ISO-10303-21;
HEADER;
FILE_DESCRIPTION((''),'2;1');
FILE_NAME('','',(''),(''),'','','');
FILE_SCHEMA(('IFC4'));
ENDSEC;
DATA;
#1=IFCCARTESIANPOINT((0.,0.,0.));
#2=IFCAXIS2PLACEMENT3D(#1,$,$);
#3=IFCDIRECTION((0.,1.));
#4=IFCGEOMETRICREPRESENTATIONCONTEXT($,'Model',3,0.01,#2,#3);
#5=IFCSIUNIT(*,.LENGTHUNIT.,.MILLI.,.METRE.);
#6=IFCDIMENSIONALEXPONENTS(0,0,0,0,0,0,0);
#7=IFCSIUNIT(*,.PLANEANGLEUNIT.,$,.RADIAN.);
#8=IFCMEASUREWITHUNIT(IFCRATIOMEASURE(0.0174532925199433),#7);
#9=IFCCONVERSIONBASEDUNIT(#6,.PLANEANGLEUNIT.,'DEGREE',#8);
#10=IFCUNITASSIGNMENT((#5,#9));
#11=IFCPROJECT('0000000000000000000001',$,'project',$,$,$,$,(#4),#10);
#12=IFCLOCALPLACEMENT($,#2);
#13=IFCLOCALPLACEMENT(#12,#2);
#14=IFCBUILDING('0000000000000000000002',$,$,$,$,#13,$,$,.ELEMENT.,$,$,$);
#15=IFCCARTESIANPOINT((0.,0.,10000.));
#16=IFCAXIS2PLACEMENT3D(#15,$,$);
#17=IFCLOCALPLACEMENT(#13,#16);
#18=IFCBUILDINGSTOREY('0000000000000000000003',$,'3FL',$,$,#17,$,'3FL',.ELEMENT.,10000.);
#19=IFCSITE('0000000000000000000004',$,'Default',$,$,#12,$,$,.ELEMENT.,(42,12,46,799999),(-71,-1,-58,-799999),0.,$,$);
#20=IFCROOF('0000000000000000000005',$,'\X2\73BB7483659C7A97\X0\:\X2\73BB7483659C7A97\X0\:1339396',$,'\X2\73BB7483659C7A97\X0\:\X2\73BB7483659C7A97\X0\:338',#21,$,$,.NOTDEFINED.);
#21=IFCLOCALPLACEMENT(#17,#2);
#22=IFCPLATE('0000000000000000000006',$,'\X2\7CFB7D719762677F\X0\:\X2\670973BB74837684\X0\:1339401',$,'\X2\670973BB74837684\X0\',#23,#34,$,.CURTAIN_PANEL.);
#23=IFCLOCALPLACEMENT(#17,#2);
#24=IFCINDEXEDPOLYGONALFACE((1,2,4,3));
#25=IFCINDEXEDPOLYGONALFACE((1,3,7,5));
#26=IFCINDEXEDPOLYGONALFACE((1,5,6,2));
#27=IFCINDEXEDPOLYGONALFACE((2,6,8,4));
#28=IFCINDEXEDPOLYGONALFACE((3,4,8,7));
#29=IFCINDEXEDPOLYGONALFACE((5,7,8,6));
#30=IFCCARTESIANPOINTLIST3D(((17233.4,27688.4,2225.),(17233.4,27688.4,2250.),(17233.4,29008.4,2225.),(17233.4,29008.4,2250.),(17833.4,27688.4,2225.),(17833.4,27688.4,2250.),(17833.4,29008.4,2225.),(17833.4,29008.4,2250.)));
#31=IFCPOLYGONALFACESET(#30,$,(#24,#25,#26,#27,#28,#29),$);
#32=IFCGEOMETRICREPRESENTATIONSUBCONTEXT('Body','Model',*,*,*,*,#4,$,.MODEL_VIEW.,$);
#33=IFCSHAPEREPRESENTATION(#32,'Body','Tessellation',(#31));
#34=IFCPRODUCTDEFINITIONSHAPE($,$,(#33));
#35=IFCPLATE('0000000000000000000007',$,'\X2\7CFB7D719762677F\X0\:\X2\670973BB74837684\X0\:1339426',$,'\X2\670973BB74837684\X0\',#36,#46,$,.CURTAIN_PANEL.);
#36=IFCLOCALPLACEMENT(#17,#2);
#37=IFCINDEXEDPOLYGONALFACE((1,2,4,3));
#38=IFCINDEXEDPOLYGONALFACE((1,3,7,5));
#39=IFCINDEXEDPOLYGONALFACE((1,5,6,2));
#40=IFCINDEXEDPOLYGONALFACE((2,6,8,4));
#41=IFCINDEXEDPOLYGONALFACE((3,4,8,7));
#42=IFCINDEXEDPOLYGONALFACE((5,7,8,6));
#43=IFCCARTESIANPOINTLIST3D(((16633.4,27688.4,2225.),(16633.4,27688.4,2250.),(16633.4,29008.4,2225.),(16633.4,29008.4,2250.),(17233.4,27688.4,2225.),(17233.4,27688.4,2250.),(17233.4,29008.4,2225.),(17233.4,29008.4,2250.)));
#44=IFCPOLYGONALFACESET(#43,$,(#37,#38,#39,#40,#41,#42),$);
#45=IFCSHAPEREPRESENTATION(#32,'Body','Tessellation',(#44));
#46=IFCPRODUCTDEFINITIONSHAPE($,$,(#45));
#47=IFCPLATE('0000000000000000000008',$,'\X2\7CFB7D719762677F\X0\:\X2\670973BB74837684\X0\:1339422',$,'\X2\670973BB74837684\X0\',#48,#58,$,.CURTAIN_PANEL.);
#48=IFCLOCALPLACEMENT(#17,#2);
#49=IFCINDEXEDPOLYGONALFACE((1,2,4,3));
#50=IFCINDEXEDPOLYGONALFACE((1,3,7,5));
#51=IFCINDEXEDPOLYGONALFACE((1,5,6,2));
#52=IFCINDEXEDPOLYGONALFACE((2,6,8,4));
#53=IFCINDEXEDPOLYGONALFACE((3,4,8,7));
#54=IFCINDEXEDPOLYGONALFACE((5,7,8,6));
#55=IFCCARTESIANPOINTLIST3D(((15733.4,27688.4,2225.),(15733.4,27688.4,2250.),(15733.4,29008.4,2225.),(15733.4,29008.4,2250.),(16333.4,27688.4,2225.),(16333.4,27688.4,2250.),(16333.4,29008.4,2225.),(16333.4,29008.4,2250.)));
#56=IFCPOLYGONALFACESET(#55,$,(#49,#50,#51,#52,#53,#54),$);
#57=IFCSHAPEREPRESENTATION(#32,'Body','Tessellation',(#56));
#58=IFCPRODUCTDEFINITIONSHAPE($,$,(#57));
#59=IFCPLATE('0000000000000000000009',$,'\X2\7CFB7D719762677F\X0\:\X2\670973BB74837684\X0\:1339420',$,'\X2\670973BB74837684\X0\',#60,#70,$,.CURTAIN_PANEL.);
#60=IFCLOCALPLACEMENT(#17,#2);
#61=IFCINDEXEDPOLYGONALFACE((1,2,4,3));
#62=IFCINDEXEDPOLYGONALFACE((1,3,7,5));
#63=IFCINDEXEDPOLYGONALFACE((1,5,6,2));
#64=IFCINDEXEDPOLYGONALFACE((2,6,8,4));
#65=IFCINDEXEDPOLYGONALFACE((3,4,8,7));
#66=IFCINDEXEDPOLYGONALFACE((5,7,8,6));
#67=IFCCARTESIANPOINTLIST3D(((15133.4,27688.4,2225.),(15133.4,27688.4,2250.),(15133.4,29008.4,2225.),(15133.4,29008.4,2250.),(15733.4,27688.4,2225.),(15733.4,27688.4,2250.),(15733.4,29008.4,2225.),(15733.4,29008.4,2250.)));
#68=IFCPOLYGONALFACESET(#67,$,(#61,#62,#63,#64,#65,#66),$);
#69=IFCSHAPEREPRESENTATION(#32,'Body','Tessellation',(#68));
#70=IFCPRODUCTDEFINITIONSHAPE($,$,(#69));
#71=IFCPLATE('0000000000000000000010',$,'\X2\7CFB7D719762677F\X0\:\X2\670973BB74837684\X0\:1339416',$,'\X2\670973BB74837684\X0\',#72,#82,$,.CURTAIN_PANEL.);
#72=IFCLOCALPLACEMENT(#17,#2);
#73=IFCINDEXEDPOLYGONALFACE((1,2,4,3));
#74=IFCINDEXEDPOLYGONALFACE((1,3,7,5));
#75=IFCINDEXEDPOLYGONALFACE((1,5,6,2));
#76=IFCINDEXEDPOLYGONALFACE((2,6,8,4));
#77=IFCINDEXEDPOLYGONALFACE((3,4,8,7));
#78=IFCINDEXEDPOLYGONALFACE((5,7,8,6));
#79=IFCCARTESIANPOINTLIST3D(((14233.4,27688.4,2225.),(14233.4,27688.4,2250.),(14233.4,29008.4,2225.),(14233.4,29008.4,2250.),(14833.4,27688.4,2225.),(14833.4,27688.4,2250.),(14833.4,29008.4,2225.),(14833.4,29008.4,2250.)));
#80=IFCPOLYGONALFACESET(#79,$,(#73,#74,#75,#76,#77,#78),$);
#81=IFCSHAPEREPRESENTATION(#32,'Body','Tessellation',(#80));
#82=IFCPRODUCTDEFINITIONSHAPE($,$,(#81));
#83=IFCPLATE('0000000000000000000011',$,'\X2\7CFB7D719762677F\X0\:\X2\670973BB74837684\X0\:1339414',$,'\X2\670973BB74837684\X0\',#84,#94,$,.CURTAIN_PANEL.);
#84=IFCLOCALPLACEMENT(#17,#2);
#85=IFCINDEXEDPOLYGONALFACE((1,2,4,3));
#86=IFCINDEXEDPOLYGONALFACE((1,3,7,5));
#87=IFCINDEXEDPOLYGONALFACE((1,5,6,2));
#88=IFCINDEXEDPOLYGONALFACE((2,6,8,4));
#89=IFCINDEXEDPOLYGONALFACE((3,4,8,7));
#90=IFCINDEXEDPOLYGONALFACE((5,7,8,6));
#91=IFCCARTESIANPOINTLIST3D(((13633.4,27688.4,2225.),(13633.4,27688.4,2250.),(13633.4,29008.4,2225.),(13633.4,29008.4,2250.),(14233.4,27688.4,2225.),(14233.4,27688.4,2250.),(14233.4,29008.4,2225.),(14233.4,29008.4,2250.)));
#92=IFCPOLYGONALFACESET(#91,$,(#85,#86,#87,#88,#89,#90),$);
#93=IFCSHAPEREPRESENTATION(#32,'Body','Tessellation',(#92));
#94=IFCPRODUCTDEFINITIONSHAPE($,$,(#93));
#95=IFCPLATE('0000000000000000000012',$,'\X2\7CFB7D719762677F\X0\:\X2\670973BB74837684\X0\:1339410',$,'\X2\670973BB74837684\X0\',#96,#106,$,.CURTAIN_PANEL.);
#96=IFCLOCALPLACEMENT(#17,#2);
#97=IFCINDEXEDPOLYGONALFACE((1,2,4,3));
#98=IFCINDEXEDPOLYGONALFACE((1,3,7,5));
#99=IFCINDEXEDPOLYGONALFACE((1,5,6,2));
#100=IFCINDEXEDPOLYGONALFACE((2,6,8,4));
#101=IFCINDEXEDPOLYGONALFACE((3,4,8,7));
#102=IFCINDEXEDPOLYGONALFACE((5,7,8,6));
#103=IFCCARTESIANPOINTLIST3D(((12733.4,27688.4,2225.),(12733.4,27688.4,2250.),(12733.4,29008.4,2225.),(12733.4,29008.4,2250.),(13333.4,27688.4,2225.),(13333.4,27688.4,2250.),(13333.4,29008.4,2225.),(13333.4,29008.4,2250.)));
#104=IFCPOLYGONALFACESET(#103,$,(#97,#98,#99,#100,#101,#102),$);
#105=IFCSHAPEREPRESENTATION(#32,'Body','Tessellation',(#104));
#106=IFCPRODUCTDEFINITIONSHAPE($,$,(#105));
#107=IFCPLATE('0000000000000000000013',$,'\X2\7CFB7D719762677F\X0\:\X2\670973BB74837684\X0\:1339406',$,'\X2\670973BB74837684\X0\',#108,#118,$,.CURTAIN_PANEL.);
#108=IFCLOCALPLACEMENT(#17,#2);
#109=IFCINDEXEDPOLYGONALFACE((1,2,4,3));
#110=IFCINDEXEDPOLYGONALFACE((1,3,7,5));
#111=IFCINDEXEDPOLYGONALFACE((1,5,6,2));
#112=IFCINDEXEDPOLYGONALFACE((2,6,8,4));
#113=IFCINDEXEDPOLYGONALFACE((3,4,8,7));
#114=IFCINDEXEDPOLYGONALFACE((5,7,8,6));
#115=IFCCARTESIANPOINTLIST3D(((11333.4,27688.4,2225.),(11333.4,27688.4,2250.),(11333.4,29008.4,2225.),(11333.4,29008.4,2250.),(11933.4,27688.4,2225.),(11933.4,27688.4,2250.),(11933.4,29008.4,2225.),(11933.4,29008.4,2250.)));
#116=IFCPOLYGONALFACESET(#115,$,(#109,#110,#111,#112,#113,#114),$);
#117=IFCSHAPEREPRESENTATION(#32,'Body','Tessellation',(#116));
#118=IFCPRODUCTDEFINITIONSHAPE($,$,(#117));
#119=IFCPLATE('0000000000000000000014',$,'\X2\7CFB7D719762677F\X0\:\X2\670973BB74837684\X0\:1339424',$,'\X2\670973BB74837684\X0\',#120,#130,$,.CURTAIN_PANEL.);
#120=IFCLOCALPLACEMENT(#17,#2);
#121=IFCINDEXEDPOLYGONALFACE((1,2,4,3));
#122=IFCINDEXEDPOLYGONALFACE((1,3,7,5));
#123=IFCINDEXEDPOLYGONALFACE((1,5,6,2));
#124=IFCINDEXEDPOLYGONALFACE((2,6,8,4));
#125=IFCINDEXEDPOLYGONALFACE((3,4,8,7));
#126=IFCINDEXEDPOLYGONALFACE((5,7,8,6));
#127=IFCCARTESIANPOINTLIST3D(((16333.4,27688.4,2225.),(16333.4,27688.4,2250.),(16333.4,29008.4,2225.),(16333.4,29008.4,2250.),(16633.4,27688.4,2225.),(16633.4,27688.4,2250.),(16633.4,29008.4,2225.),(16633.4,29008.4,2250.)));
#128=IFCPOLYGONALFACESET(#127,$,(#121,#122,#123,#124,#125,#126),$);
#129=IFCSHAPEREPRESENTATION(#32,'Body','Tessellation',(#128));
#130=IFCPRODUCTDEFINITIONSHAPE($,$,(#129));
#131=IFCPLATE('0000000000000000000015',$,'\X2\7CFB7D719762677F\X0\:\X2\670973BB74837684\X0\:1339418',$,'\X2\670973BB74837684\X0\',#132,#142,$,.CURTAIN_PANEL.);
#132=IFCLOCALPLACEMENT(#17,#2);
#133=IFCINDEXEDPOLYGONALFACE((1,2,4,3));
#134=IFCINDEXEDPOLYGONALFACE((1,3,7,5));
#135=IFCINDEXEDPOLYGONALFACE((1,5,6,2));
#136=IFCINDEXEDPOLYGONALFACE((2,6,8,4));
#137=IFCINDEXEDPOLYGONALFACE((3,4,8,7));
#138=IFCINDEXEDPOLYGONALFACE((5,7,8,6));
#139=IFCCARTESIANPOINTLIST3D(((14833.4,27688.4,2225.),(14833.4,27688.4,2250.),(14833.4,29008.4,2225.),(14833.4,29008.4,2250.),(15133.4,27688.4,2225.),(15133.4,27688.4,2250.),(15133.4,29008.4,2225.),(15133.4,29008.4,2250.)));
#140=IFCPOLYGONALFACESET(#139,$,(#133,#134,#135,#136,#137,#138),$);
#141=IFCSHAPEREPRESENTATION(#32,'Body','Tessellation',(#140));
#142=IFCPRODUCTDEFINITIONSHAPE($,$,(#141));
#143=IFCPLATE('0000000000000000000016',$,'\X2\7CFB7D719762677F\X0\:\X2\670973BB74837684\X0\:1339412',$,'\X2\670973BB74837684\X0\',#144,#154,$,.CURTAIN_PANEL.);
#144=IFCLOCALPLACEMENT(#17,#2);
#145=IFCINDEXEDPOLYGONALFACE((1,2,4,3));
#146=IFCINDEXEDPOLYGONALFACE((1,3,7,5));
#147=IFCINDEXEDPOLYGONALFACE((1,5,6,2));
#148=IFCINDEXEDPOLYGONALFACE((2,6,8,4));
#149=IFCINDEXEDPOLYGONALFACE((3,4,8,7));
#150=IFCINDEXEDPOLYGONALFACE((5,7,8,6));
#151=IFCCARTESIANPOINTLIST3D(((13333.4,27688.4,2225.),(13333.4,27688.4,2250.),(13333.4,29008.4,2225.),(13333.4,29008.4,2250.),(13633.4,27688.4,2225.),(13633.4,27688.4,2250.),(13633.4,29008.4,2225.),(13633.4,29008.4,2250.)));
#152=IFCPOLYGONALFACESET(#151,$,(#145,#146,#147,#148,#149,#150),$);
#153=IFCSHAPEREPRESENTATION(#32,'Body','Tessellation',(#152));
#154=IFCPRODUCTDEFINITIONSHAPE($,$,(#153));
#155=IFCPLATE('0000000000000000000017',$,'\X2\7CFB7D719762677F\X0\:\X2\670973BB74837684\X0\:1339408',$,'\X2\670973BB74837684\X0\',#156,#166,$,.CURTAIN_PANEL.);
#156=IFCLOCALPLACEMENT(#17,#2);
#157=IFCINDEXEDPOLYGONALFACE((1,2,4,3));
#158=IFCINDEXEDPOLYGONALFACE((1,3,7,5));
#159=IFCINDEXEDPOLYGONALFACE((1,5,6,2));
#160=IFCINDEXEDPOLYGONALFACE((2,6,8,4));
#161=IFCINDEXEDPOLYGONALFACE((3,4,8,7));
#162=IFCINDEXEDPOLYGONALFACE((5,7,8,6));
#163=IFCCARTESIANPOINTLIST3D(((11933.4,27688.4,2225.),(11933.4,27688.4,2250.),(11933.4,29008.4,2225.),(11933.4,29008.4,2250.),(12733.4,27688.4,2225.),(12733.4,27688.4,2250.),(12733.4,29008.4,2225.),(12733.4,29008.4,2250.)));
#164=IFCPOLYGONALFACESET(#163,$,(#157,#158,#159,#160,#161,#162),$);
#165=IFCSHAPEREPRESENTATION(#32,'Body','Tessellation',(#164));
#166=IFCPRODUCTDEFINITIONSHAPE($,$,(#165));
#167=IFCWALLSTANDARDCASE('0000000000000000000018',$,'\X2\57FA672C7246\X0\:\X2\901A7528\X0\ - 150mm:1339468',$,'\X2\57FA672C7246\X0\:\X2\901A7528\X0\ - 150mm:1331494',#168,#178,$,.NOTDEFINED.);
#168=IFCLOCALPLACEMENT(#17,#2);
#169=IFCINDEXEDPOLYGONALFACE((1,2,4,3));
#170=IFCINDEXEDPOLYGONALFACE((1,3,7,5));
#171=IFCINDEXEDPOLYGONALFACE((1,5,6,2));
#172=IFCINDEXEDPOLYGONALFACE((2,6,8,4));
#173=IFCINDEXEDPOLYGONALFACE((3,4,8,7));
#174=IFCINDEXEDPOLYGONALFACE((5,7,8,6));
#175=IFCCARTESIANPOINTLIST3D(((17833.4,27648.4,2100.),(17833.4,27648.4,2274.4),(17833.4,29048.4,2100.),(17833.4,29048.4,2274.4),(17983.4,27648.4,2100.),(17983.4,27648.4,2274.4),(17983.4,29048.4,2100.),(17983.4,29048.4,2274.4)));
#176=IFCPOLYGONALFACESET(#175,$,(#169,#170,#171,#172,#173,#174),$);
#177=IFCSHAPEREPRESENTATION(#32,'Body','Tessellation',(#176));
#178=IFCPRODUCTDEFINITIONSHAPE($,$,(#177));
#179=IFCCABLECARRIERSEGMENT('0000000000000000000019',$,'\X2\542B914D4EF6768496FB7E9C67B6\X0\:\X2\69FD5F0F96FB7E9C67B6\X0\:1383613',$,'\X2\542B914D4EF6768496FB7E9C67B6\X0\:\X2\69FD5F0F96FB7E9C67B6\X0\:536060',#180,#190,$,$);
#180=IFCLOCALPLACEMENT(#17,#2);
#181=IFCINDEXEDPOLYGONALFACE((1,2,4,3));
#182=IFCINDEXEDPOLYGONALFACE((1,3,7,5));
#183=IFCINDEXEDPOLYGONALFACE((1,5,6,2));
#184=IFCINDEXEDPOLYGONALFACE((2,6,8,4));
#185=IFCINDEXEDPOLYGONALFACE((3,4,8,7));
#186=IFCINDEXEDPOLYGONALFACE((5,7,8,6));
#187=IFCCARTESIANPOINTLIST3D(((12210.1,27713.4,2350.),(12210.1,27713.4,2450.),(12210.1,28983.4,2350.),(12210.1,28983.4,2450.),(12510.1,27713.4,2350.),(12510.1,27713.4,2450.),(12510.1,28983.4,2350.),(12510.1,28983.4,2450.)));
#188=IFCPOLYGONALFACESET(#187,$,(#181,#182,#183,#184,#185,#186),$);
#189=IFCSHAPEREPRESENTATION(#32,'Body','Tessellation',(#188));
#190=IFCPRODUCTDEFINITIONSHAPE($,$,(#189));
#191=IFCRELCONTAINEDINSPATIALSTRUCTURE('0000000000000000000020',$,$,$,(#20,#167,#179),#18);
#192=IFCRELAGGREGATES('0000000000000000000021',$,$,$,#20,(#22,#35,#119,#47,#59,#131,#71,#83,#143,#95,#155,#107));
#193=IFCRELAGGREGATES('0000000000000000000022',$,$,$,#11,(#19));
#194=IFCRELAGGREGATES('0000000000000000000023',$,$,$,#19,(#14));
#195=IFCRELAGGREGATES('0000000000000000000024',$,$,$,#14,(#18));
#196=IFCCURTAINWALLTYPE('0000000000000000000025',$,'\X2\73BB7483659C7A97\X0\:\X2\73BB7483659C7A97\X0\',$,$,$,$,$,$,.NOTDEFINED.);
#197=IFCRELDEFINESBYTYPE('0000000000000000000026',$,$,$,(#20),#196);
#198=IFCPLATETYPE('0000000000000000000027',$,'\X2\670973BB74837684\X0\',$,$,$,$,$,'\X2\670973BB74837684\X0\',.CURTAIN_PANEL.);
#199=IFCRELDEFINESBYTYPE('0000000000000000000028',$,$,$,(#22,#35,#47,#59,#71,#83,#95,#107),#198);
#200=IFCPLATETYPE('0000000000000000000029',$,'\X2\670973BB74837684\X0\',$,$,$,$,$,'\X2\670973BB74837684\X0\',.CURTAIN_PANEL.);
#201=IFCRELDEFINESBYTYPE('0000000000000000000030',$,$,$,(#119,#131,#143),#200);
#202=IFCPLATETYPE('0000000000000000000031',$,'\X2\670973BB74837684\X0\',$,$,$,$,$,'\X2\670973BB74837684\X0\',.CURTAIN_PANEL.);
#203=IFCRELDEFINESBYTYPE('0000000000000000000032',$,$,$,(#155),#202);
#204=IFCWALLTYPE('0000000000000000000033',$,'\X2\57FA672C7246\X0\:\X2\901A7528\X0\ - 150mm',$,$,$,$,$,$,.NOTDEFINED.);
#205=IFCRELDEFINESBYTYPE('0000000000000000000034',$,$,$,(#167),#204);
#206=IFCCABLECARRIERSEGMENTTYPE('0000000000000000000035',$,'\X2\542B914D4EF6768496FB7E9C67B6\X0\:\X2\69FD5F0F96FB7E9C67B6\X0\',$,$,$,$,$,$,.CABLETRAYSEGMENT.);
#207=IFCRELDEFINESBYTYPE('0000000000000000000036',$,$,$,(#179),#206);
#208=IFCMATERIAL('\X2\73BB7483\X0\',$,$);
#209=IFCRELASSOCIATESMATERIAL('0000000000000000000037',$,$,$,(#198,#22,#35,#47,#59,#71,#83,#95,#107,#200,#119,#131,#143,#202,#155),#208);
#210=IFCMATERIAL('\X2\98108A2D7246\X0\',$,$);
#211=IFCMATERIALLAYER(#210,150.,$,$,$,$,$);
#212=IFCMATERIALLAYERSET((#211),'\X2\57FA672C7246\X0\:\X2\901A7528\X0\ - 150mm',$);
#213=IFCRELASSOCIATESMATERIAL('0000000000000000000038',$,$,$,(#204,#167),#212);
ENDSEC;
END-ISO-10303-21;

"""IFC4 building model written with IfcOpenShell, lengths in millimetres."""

from ifc_helpers import new_model, entity, si_unit, converted_unit, direction, frame, frame_2d, origin, origin_2d_with_axis, place, context, subcontext, project, spatial, rectangle, extrude, source, transform, mapped, material, layer, layer_set, layer_usage, type_object, type_shapes, element, aggregate, save


model = new_model("IFC4")

# Units and contexts
model_context = context("Model", 3, precision=0.01, world=origin(), true_north=direction((0.0, 1.0)))
body_context = subcontext(model_context, "Body", "Model", "MODEL_VIEW")
ifc_project = project(units=[si_unit("LENGTHUNIT", "METRE", prefix="MILLI"), converted_unit("PLANEANGLEUNIT", "DEGREE", entity("IfcRatioMeasure", 0.0174532925199433), si_unit("PLANEANGLEUNIT", "RADIAN"), dimensions=[0, 0, 0, 0, 0, 0, 0])], contexts=[model_context])

# Site, building, storey
site_placement = place(None, origin())
site = spatial("IfcSite", under=ifc_project, at=site_placement, Name="Default", CompositionType="ELEMENT", RefLatitude=(42, 12, 46, 799999), RefLongitude=(-71, -1, -58, -799999), RefElevation=0.0)
building_placement = place(site_placement, origin())
building = spatial("IfcBuilding", under=site, at=building_placement, CompositionType="ELEMENT")
storey_placement = place(building_placement, frame((0.0, 0.0, 10000.0)))
storey = spatial("IfcBuildingStorey", under=building, at=storey_placement, Name="3FL", LongName="3FL", CompositionType="ELEMENT", Elevation=10000.0)

# Roof, plates
curtain_wall_type = type_object("IfcCurtainWallType", Name="玻璃斜窗:玻璃斜窗", PredefinedType="NOTDEFINED")
roof_placement = place(storey_placement, frame((0.0, 0.0, -10000.0)))
roof = element("IfcRoof", 1, at=roof_placement, inside=storey, type_object=curtain_wall_type, Name="玻璃斜窗:玻璃斜窗:1339396", ObjectType="玻璃斜窗:玻璃斜窗:338", PredefinedType="NOTDEFINED")
ifc_material_1 = material(Name="玻璃")
plate_type_1 = type_object("IfcPlateType", Name="有玻璃的", ElementType="有玻璃的", PredefinedType="CURTAIN_PANEL", material=ifc_material_1)
shared_shape_1 = source(origin(), body_context, "Body", "SweptSolid", [
    extrude(rectangle(XDim=25.0, YDim=600.0, at=origin_2d_with_axis()), frame((300.0, 12.5, 0.0), z_axis=(0.0, 0.0, 1.0), x_axis=(0.0, 1.0, 0.0)), (0.0, 0.0, 1.0), 1320.0),
])
type_shapes(plate_type_1, [shared_shape_1])
plate_1_placement = place(roof_placement, frame((17833.4, 29008.4, 12250.0), z_axis=(0.0, -1.0, 0.0), x_axis=(-1.0, 0.0, 0.0)))
plate_1 = element("IfcPlate", 2, at=plate_1_placement, type_object=plate_type_1, material=ifc_material_1, Name="系統面板:有玻璃的:1339401", ObjectType="有玻璃的", PredefinedType="CURTAIN_PANEL", context=body_context, shape_type="MappedRepresentation", body=[
    mapped(shared_shape_1, transform((0.0, 0.0, 0.0), scale=1.0)),
])
plate_2_placement = place(roof_placement, frame((17233.4, 29008.4, 12250.0), z_axis=(0.0, -1.0, 0.0), x_axis=(-1.0, 0.0, 0.0)))
plate_2 = element("IfcPlate", 3, at=plate_2_placement, type_object=plate_type_1, material=ifc_material_1, Name="系統面板:有玻璃的:1339426", ObjectType="有玻璃的", PredefinedType="CURTAIN_PANEL", context=body_context, shape_type="MappedRepresentation", body=[
    mapped(shared_shape_1, transform((0.0, 0.0, 0.0), scale=1.0)),
])
plate_3_placement = place(roof_placement, frame((16333.4, 29008.4, 12250.0), z_axis=(0.0, -1.0, 0.0), x_axis=(-1.0, 0.0, 0.0)))
plate_3 = element("IfcPlate", 4, at=plate_3_placement, type_object=plate_type_1, material=ifc_material_1, Name="系統面板:有玻璃的:1339422", ObjectType="有玻璃的", PredefinedType="CURTAIN_PANEL", context=body_context, shape_type="MappedRepresentation", body=[
    mapped(shared_shape_1, transform((0.0, 0.0, 0.0), scale=1.0)),
])
plate_4_placement = place(roof_placement, frame((15733.4, 29008.4, 12250.0), z_axis=(0.0, -1.0, 0.0), x_axis=(-1.0, 0.0, 0.0)))
plate_4 = element("IfcPlate", 5, at=plate_4_placement, type_object=plate_type_1, material=ifc_material_1, Name="系統面板:有玻璃的:1339420", ObjectType="有玻璃的", PredefinedType="CURTAIN_PANEL", context=body_context, shape_type="MappedRepresentation", body=[
    mapped(shared_shape_1, transform((0.0, 0.0, 0.0), scale=1.0)),
])
plate_5_placement = place(roof_placement, frame((14833.4, 29008.4, 12250.0), z_axis=(0.0, -1.0, 0.0), x_axis=(-1.0, 0.0, 0.0)))
plate_5 = element("IfcPlate", 6, at=plate_5_placement, type_object=plate_type_1, material=ifc_material_1, Name="系統面板:有玻璃的:1339416", ObjectType="有玻璃的", PredefinedType="CURTAIN_PANEL", context=body_context, shape_type="MappedRepresentation", body=[
    mapped(shared_shape_1, transform((0.0, 0.0, 0.0), scale=1.0)),
])
plate_6_placement = place(roof_placement, frame((14233.4, 29008.4, 12250.0), z_axis=(0.0, -1.0, 0.0), x_axis=(-1.0, 0.0, 0.0)))
plate_6 = element("IfcPlate", 7, at=plate_6_placement, type_object=plate_type_1, material=ifc_material_1, Name="系統面板:有玻璃的:1339414", ObjectType="有玻璃的", PredefinedType="CURTAIN_PANEL", context=body_context, shape_type="MappedRepresentation", body=[
    mapped(shared_shape_1, transform((0.0, 0.0, 0.0), scale=1.0)),
])
plate_7_placement = place(roof_placement, frame((13333.4, 29008.4, 12250.0), z_axis=(0.0, -1.0, 0.0), x_axis=(-1.0, 0.0, 0.0)))
plate_7 = element("IfcPlate", 8, at=plate_7_placement, type_object=plate_type_1, material=ifc_material_1, Name="系統面板:有玻璃的:1339410", ObjectType="有玻璃的", PredefinedType="CURTAIN_PANEL", context=body_context, shape_type="MappedRepresentation", body=[
    mapped(shared_shape_1, transform((0.0, 0.0, 0.0), scale=1.0)),
])
plate_8_placement = place(roof_placement, frame((11933.4, 29008.4, 12250.0), z_axis=(0.0, -1.0, 0.0), x_axis=(-1.0, 0.0, 0.0)))
plate_8 = element("IfcPlate", 9, at=plate_8_placement, type_object=plate_type_1, material=ifc_material_1, Name="系統面板:有玻璃的:1339406", ObjectType="有玻璃的", PredefinedType="CURTAIN_PANEL", context=body_context, shape_type="MappedRepresentation", body=[
    mapped(shared_shape_1, transform((0.0, 0.0, 0.0), scale=1.0)),
])
plate_type_2 = type_object("IfcPlateType", Name="有玻璃的", ElementType="有玻璃的", PredefinedType="CURTAIN_PANEL", material=ifc_material_1)
shared_shape_2 = source(origin(), body_context, "Body", "SweptSolid", [
    extrude(rectangle(XDim=25.0, YDim=300.0, at=origin_2d_with_axis()), frame((150.0, 12.5, 0.0), z_axis=(0.0, 0.0, 1.0), x_axis=(0.0, 1.0, 0.0)), (0.0, 0.0, 1.0), 1320.0),
])
type_shapes(plate_type_2, [shared_shape_2])
plate_9_placement = place(roof_placement, frame((16633.4, 29008.4, 12250.0), z_axis=(0.0, -1.0, 0.0), x_axis=(-1.0, 0.0, 0.0)))
plate_9 = element("IfcPlate", 10, at=plate_9_placement, type_object=plate_type_2, material=ifc_material_1, Name="系統面板:有玻璃的:1339424", ObjectType="有玻璃的", PredefinedType="CURTAIN_PANEL", context=body_context, shape_type="MappedRepresentation", body=[
    mapped(shared_shape_2, transform((0.0, 0.0, 0.0), scale=1.0)),
])
plate_10_placement = place(roof_placement, frame((15133.4, 29008.4, 12250.0), z_axis=(0.0, -1.0, 0.0), x_axis=(-1.0, 0.0, 0.0)))
plate_10 = element("IfcPlate", 11, at=plate_10_placement, type_object=plate_type_2, material=ifc_material_1, Name="系統面板:有玻璃的:1339418", ObjectType="有玻璃的", PredefinedType="CURTAIN_PANEL", context=body_context, shape_type="MappedRepresentation", body=[
    mapped(shared_shape_2, transform((0.0, 0.0, 0.0), scale=1.0)),
])
plate_11_placement = place(roof_placement, frame((13633.4, 29008.4, 12250.0), z_axis=(0.0, -1.0, 0.0), x_axis=(-1.0, 0.0, 0.0)))
plate_11 = element("IfcPlate", 12, at=plate_11_placement, type_object=plate_type_2, material=ifc_material_1, Name="系統面板:有玻璃的:1339412", ObjectType="有玻璃的", PredefinedType="CURTAIN_PANEL", context=body_context, shape_type="MappedRepresentation", body=[
    mapped(shared_shape_2, transform((0.0, 0.0, 0.0), scale=1.0)),
])
plate_type_3 = type_object("IfcPlateType", Name="有玻璃的", ElementType="有玻璃的", PredefinedType="CURTAIN_PANEL", material=ifc_material_1)
shared_shape_3 = source(origin(), body_context, "Body", "SweptSolid", [
    extrude(rectangle(XDim=25.0, YDim=800.0, at=origin_2d_with_axis()), frame((400.0, 12.5, 0.0), z_axis=(0.0, 0.0, 1.0), x_axis=(0.0, 1.0, 0.0)), (0.0, 0.0, 1.0), 1320.0),
])
type_shapes(plate_type_3, [shared_shape_3])
plate_12_placement = place(roof_placement, frame((12733.4, 29008.4, 12250.0), z_axis=(0.0, -1.0, 0.0), x_axis=(-1.0, 0.0, 0.0)))
plate_12 = element("IfcPlate", 13, at=plate_12_placement, type_object=plate_type_3, material=ifc_material_1, Name="系統面板:有玻璃的:1339408", ObjectType="有玻璃的", PredefinedType="CURTAIN_PANEL", context=body_context, shape_type="MappedRepresentation", body=[
    mapped(shared_shape_3, transform((0.0, 0.0, 0.0), scale=1.0)),
])
aggregate(roof, [plate_1, plate_2, plate_9, plate_3, plate_4, plate_10, plate_5, plate_6, plate_11, plate_7, plate_12, plate_8])

# Wall, opening
ifc_material_2 = material(Name="預設牆")
ifc_layer = layer(ifc_material_2, 150.0)
ifc_layer_set = layer_set([ifc_layer], Name="基本牆:通用 - 150mm")
ifc_layer_usage = layer_usage(ifc_layer_set, "AXIS2", "POSITIVE", -75.0)
wall_type = type_object("IfcWallType", Name="基本牆:通用 - 150mm", PredefinedType="NOTDEFINED", material=ifc_layer_set)
wall_placement = place(storey_placement, frame((17908.4, 29048.4, 2100.0), z_axis=(0.0, 0.0, 1.0), x_axis=(0.0, -1.0, 0.0)))
wall = element("IfcWallStandardCase", 14, at=wall_placement, inside=storey, type_object=wall_type, material=ifc_layer_usage, Name="基本牆:通用 - 150mm:1339468", ObjectType="基本牆:通用 - 150mm:1331494", PredefinedType="NOTDEFINED", context=body_context, shape_type="SweptSolid", body=[
    extrude(rectangle(XDim=1400.0, YDim=150.0, at=frame_2d((700.0, 0.0), x_axis=(-1.0, 0.0))), origin(), (0.0, 0.0, 1.0), 174.4),
])
opening_placement = place(wall_placement, frame((0.0, -75.0, -2100.0)))
element("IfcOpeningElement", 15, at=opening_placement, cuts=wall, ObjectType="Opening", PredefinedType="OPENING", context=body_context, shape_type="SweptSolid", body=[
    extrude(rectangle(XDim=2100.0, YDim=1400.0, at=frame_2d((1050.0, 700.0), x_axis=(1.0, 0.0))), frame((0.0, 0.0, 0.0), z_axis=(0.0, 1.0, 0.0), x_axis=(0.0, 0.0, 1.0)), (0.0, 0.0, 1.0), 150.0),
])

# Cable carrier segment
cable_carrier_segment_type_1 = type_object("IfcCableCarrierSegmentType", Name="含配件的電纜架:槽式電纜架", PredefinedType="CABLETRAYSEGMENT")
cable_carrier_segment_1_placement = place(storey_placement, frame((12210.1, 27713.4, 2350.0)))
element("IfcCableCarrierSegment", 16, at=cable_carrier_segment_1_placement, inside=storey, type_object=cable_carrier_segment_type_1, Name="含配件的電纜架:槽式電纜架:1383613", ObjectType="含配件的電纜架:槽式電纜架:536060", context=body_context, shape_type="SweptSolid", body=[
    extrude(rectangle(XDim=1270.0, YDim=300.0, at=origin_2d_with_axis()), frame((150.0, 635.0, 0.0), z_axis=(0.0, 0.0, 1.0), x_axis=(0.0, 1.0, 0.0)), (0.0, 0.0, 1.0), 100.0),
])

save(model, "model.ifc")
